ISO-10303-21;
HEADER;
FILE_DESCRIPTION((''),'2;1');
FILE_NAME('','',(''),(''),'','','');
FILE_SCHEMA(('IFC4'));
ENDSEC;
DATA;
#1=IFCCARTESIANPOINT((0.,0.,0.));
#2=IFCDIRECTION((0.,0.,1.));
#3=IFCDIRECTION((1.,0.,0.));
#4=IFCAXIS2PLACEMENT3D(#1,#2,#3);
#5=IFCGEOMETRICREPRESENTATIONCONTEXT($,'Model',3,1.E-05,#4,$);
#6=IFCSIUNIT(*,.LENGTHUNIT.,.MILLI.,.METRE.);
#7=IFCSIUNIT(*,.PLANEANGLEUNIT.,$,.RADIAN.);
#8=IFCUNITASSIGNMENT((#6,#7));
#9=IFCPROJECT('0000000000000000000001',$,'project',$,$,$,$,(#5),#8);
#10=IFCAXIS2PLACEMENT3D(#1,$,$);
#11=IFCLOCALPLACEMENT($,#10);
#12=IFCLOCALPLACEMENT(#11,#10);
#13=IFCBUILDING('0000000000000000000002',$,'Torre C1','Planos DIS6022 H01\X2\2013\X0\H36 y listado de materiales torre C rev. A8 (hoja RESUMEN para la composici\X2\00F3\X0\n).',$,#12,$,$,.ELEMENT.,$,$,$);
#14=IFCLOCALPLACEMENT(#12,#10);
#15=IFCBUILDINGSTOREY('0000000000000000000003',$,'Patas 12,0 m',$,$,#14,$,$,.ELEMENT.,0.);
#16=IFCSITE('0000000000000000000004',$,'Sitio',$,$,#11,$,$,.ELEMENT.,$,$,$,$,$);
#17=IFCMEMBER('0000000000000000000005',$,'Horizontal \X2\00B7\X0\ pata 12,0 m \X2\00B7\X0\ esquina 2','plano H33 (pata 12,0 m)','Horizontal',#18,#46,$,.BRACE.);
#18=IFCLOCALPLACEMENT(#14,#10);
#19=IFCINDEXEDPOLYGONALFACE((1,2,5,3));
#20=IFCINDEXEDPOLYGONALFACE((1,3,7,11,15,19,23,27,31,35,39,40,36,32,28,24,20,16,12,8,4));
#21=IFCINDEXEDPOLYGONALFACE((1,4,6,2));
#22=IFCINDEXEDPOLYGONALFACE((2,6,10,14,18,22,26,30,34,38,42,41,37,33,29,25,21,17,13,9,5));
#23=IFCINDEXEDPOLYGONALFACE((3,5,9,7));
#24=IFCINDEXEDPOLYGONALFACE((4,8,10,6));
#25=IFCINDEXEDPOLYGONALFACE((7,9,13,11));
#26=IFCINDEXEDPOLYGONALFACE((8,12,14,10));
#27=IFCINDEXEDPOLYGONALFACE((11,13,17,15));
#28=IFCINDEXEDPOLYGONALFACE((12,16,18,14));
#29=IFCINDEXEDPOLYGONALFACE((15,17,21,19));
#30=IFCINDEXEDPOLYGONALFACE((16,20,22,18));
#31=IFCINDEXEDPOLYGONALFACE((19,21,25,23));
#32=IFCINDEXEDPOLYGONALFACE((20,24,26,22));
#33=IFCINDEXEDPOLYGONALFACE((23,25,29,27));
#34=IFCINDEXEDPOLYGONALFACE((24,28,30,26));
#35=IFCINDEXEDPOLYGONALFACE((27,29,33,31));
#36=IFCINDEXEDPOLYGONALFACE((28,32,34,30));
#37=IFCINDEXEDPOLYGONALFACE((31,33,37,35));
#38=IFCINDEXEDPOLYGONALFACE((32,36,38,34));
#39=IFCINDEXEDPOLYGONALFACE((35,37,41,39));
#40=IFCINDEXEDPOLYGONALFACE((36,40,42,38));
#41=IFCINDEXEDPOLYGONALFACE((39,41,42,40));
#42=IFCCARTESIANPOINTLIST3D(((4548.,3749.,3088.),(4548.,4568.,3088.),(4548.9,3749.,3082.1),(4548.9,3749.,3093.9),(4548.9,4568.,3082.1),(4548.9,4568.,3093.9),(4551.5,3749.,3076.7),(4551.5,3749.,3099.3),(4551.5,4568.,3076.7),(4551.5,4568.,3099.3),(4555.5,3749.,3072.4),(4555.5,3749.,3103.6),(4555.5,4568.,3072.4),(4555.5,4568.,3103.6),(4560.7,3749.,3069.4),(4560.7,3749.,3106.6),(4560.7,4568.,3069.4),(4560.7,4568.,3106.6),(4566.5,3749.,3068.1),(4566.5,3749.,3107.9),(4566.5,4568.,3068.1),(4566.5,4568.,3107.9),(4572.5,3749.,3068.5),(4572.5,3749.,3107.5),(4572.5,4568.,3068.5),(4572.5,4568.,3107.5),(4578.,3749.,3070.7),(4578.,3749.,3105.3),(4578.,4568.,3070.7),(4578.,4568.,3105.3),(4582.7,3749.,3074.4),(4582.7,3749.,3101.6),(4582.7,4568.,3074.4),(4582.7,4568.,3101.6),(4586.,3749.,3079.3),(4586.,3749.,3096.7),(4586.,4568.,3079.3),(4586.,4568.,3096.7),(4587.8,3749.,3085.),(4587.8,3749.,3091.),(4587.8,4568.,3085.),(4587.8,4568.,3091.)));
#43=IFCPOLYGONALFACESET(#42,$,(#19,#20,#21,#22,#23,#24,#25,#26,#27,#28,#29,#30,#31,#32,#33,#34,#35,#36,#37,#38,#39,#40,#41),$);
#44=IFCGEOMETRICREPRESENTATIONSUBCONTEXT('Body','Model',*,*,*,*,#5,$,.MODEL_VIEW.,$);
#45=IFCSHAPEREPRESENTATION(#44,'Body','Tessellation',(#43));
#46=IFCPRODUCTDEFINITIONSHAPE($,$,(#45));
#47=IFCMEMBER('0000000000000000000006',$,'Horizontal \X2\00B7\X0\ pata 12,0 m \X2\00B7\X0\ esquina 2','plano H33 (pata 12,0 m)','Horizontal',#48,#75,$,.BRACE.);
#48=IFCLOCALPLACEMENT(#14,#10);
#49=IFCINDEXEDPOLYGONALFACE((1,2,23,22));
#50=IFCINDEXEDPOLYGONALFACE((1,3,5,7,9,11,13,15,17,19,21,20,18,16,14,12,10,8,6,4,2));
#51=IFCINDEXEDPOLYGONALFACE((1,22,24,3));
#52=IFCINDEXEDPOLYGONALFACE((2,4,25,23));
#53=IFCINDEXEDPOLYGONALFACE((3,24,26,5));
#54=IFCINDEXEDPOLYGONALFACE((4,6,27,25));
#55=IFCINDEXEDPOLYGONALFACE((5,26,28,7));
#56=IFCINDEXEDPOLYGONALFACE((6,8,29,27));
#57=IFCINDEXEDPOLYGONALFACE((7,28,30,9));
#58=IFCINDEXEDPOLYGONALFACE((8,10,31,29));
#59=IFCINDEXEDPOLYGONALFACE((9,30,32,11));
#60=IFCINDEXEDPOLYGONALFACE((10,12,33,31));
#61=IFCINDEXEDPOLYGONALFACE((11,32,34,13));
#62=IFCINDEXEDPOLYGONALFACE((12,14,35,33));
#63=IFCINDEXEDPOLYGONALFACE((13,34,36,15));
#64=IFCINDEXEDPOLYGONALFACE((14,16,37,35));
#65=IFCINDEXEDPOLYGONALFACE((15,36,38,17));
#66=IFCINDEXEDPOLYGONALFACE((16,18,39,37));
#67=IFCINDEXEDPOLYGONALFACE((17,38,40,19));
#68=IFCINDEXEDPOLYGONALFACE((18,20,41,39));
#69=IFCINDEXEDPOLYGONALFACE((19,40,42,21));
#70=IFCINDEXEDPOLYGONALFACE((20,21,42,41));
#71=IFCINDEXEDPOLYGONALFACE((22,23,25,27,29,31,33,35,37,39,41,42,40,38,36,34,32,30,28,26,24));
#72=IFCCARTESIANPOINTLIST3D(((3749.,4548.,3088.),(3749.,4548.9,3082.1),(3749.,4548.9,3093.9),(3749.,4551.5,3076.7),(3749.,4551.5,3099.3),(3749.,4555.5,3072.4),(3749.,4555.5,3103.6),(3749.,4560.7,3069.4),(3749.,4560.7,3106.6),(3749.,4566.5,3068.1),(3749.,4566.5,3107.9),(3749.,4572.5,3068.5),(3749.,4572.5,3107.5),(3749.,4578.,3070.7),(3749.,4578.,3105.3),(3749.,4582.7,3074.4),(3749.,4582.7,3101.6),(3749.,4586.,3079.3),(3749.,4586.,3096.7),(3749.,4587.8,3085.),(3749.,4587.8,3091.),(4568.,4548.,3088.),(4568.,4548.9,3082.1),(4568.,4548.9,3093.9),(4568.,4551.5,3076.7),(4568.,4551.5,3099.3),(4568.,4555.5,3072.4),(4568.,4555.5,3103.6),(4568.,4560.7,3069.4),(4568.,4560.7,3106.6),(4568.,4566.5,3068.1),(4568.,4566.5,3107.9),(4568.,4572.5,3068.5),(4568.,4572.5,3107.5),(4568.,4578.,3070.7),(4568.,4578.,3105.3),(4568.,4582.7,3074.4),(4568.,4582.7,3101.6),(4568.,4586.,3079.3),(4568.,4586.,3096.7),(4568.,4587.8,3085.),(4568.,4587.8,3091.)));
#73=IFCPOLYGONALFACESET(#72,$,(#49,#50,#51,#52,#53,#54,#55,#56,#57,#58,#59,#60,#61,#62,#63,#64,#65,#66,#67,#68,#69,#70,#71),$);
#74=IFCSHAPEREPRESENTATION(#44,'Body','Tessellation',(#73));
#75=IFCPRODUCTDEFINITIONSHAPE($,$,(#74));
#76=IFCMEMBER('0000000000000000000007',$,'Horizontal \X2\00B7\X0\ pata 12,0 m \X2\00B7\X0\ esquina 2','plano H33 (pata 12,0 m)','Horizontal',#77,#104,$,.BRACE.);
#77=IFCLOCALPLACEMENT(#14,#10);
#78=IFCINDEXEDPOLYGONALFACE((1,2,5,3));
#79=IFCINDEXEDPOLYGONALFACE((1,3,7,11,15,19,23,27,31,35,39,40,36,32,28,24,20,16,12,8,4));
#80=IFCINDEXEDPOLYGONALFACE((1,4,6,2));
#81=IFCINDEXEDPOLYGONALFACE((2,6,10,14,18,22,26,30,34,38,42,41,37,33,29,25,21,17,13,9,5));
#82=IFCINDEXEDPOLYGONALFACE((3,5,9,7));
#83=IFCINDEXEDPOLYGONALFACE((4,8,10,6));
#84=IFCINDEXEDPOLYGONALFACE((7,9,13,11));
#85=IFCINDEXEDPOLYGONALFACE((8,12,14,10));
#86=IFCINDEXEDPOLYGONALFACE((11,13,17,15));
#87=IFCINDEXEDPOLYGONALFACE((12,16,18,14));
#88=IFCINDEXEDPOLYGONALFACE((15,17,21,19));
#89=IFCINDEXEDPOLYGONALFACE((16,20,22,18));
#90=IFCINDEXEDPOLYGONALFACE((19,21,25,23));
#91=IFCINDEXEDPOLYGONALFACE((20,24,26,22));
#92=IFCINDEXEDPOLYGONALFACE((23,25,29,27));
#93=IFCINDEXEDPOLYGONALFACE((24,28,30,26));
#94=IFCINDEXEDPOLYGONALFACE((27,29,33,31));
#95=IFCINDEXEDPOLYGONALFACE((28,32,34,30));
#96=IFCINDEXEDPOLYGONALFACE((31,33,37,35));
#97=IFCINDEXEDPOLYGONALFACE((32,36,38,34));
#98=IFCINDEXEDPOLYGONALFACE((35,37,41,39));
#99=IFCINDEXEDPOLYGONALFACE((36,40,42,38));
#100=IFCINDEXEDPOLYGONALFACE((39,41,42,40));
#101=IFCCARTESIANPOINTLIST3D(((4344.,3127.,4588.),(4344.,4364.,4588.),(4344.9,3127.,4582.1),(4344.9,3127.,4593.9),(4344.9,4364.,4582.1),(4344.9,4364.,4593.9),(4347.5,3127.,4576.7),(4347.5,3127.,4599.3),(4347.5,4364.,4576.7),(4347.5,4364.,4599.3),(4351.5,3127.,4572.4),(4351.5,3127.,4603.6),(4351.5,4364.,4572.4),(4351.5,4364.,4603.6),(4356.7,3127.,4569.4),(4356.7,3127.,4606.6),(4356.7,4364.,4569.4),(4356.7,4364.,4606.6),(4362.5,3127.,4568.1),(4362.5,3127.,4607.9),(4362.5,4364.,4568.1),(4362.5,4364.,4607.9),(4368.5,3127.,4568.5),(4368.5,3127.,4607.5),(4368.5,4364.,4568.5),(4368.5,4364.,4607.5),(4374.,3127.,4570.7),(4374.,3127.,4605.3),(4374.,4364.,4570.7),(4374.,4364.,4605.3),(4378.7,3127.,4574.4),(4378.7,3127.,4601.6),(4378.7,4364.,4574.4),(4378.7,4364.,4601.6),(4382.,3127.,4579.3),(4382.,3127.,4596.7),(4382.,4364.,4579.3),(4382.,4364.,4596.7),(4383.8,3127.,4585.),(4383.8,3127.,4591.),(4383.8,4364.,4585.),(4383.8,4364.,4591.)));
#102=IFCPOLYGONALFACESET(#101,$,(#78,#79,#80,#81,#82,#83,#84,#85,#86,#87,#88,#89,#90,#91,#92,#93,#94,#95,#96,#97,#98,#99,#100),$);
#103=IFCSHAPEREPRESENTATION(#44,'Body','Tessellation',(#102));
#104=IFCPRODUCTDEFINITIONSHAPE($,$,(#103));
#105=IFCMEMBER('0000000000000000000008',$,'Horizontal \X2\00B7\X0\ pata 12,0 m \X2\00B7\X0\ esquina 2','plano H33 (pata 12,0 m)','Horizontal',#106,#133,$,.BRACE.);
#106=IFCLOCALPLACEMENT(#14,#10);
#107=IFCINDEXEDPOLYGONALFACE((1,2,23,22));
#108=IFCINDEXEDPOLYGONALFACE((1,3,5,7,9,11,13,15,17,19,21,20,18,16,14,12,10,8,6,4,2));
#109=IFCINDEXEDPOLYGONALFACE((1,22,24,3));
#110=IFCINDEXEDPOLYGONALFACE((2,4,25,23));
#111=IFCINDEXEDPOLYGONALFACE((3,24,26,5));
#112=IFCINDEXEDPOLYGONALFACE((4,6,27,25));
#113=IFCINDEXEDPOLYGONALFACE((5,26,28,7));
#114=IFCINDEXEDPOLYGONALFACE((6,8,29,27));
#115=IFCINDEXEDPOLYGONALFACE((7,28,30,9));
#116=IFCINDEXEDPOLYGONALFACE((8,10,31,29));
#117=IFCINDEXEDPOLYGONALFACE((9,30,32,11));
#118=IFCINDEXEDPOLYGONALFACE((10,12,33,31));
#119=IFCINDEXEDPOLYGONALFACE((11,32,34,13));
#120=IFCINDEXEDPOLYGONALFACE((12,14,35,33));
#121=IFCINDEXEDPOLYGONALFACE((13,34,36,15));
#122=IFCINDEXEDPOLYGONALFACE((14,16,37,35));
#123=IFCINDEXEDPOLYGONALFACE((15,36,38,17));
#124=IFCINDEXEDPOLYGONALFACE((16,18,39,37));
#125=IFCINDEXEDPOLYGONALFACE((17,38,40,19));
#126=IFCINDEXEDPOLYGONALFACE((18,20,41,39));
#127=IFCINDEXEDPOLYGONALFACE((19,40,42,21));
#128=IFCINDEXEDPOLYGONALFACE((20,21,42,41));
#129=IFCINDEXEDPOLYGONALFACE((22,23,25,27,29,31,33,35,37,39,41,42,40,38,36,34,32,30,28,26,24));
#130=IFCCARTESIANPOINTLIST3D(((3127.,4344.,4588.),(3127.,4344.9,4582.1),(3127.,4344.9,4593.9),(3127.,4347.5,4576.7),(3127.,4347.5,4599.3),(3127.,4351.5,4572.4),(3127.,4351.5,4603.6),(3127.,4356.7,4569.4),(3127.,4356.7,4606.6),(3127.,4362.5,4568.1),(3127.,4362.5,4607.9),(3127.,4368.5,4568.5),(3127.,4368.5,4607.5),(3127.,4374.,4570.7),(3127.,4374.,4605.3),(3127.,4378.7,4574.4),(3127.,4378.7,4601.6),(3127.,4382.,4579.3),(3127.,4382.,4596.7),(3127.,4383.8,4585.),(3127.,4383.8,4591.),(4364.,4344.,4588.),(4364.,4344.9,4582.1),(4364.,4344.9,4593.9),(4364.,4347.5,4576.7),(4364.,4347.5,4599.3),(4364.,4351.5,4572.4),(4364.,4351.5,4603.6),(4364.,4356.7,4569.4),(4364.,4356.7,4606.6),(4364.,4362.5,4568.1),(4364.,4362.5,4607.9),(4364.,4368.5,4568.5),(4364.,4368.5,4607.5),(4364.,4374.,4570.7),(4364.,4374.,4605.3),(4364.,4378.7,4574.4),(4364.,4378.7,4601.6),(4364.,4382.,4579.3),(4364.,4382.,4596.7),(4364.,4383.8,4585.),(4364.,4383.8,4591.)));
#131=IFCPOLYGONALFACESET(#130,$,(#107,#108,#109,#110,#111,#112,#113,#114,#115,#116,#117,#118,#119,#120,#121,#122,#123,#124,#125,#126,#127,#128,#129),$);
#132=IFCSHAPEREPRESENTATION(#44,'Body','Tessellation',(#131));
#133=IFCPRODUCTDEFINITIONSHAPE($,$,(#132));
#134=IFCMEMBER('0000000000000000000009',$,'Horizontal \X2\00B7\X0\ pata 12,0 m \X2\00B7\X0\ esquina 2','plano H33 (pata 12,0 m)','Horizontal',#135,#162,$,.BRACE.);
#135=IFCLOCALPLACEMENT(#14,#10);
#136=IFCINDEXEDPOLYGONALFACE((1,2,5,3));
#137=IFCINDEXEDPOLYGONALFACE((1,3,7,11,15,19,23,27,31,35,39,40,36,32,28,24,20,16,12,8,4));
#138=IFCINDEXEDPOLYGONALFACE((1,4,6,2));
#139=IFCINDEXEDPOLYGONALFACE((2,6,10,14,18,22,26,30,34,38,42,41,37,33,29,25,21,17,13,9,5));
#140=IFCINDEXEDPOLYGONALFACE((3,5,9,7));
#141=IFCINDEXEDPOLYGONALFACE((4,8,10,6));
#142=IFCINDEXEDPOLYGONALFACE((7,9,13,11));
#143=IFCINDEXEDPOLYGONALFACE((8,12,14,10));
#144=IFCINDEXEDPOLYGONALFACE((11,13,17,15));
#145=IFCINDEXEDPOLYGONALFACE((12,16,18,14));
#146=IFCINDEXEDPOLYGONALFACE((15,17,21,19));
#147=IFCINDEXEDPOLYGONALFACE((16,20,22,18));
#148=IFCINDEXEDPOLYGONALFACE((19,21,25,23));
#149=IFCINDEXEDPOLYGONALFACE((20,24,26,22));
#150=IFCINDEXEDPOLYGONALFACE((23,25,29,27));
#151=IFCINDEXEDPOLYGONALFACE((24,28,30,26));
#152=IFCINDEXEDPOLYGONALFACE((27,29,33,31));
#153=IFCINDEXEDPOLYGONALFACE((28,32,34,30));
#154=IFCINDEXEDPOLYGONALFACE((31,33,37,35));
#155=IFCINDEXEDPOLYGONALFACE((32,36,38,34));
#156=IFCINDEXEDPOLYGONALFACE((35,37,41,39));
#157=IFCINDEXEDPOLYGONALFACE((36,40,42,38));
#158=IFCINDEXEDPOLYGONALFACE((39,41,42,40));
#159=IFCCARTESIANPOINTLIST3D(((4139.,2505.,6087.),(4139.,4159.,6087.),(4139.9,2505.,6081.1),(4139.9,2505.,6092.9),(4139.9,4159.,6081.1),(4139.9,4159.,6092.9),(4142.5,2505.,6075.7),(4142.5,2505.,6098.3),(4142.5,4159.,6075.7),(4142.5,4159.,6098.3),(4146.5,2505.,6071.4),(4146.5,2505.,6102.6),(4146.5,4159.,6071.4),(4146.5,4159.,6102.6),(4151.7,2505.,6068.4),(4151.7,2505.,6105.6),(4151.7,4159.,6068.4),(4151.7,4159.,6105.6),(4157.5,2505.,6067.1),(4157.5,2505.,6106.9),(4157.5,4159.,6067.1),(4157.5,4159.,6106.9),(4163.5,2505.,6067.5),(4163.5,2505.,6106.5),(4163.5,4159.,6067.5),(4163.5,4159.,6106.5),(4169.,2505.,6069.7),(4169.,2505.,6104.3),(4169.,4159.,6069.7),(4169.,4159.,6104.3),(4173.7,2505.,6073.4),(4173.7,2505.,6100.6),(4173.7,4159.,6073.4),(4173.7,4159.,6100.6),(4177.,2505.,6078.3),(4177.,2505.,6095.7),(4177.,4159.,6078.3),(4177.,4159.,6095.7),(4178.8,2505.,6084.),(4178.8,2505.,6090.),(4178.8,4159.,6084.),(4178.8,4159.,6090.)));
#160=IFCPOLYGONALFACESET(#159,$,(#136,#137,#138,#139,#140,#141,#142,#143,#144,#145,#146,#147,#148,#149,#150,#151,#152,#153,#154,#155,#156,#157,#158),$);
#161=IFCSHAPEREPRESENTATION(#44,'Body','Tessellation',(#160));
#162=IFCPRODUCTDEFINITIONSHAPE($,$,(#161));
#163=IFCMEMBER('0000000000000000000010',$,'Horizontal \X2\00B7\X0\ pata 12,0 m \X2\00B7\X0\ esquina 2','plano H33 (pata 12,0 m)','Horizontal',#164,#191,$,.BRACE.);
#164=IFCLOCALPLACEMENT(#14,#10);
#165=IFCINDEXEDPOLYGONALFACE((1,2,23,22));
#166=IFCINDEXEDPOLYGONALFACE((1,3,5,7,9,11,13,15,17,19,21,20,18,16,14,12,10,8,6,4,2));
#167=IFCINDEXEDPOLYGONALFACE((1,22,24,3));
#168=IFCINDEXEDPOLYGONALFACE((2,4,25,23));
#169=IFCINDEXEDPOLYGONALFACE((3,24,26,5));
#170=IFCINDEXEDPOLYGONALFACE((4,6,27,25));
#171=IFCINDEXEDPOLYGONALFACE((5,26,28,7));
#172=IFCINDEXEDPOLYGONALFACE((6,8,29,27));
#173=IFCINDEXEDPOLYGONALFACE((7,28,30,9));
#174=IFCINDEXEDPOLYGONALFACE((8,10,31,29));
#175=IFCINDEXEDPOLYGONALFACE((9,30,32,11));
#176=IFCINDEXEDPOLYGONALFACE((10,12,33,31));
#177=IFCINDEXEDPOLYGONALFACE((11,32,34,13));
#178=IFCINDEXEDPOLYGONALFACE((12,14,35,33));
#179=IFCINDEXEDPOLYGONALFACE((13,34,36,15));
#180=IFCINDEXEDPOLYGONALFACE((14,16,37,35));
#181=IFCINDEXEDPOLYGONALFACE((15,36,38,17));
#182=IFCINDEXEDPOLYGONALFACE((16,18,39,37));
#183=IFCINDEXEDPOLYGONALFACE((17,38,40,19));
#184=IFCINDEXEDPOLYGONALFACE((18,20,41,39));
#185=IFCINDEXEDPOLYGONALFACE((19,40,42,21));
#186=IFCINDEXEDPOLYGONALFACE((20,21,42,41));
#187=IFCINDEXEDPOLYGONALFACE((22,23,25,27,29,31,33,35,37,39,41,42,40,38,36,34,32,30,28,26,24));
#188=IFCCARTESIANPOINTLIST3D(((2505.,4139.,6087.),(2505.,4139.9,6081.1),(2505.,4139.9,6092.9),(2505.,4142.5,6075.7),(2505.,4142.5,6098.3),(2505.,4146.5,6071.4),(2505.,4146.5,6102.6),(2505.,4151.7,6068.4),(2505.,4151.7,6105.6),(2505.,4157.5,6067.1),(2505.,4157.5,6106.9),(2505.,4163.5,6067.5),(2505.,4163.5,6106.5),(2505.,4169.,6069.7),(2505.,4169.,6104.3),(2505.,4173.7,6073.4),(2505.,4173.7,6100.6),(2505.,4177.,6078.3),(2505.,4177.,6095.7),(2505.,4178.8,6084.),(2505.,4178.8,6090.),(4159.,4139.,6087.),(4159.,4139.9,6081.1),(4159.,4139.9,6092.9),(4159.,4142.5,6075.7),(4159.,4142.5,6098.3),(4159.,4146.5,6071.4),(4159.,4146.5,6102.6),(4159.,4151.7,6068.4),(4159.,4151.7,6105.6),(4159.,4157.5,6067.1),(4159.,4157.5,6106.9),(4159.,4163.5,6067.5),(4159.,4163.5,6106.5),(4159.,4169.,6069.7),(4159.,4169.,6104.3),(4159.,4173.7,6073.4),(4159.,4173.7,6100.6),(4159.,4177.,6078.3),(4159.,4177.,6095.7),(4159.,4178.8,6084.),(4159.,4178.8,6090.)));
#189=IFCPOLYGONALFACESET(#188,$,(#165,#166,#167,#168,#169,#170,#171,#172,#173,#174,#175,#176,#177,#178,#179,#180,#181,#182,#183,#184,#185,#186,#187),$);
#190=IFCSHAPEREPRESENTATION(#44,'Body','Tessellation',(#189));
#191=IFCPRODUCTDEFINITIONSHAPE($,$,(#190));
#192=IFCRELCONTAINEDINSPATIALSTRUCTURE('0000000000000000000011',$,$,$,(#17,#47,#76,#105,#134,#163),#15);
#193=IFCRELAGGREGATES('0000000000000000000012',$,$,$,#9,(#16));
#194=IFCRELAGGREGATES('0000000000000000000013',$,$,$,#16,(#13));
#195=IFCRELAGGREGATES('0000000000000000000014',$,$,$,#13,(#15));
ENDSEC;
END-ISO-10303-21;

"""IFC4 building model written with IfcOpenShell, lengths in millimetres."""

from ifc_helpers import new_model, si_unit, frame, origin, origin_with_axes, place, context, subcontext, project, spatial, circle, extrude, element, save


model = new_model("IFC4")

# Units and contexts
model_context = context("Model", 3, precision=1e-05, world=origin_with_axes())
body_context = subcontext(model_context, "Body", "Model", "MODEL_VIEW")
ifc_project = project(units=[si_unit("LENGTHUNIT", "METRE", prefix="MILLI"), si_unit("PLANEANGLEUNIT", "RADIAN")], contexts=[model_context])

# Site, building, storey
site_placement = place(None, origin())
site = spatial("IfcSite", under=ifc_project, at=site_placement, Name="Sitio", CompositionType="ELEMENT")
building_placement = place(site_placement, origin())
building = spatial("IfcBuilding", under=site, at=building_placement, Name="Torre C1", Description="Planos DIS6022 H01–H36 y listado de materiales torre C rev. A8 (hoja RESUMEN para la composición).", CompositionType="ELEMENT")
storey_placement = place(building_placement, origin())
storey = spatial("IfcBuildingStorey", under=building, at=storey_placement, Name="Patas 12,0 m", CompositionType="ELEMENT", Elevation=0.0)

# Members
for number, where, z_axis, x_axis, name in (
    (1, (4568.0, 4568.0, 3088.0), (0.0, -1.0, 0.0), (-1.0, 0.0, 0.0), "Horizontal · pata 12,0 m · esquina 2"),
    (2, (4568.0, 4568.0, 3088.0), (-1.0, 0.0, 0.0), (0.0, -1.0, 0.0), "Horizontal · pata 12,0 m · esquina 2"),
):
    element("IfcMember", number, at=place(storey_placement, frame(where, z_axis=z_axis, x_axis=x_axis)), inside=storey, Name=name, Description="plano H33 (pata 12,0 m)", ObjectType="Horizontal", PredefinedType="BRACE", context=body_context, shape_type="SweptSolid", body=[
        extrude(circle(Radius=20.0), None, (0.0, 0.0, 1.0), 819.0),
    ])
for number, where, z_axis, x_axis, name in (
    (3, (4364.0, 4364.0, 4588.0), (0.0, -1.0, 0.0), (-1.0, 0.0, 0.0), "Horizontal · pata 12,0 m · esquina 2"),
    (4, (4364.0, 4364.0, 4588.0), (-1.0, 0.0, 0.0), (0.0, -1.0, 0.0), "Horizontal · pata 12,0 m · esquina 2"),
):
    element("IfcMember", number, at=place(storey_placement, frame(where, z_axis=z_axis, x_axis=x_axis)), inside=storey, Name=name, Description="plano H33 (pata 12,0 m)", ObjectType="Horizontal", PredefinedType="BRACE", context=body_context, shape_type="SweptSolid", body=[
        extrude(circle(Radius=20.0), None, (0.0, 0.0, 1.0), 1237.0),
    ])
for number, where, z_axis, x_axis, name in (
    (5, (4159.0, 2505.0, 6087.0), (0.0, 1.0, 0.0), (-1.0, 0.0, 0.0), "Horizontal · pata 12,0 m · esquina 2"),
    (6, (2505.0, 4159.0, 6087.0), (1.0, 0.0, 0.0), (0.0, -1.0, 0.0), "Horizontal · pata 12,0 m · esquina 2"),
):
    element("IfcMember", number, at=place(storey_placement, frame(where, z_axis=z_axis, x_axis=x_axis)), inside=storey, Name=name, Description="plano H33 (pata 12,0 m)", ObjectType="Horizontal", PredefinedType="BRACE", context=body_context, shape_type="SweptSolid", body=[
        extrude(circle(Radius=20.0), None, (0.0, 0.0, 1.0), 1654.0),
    ])

save(model, "model.ifc")
